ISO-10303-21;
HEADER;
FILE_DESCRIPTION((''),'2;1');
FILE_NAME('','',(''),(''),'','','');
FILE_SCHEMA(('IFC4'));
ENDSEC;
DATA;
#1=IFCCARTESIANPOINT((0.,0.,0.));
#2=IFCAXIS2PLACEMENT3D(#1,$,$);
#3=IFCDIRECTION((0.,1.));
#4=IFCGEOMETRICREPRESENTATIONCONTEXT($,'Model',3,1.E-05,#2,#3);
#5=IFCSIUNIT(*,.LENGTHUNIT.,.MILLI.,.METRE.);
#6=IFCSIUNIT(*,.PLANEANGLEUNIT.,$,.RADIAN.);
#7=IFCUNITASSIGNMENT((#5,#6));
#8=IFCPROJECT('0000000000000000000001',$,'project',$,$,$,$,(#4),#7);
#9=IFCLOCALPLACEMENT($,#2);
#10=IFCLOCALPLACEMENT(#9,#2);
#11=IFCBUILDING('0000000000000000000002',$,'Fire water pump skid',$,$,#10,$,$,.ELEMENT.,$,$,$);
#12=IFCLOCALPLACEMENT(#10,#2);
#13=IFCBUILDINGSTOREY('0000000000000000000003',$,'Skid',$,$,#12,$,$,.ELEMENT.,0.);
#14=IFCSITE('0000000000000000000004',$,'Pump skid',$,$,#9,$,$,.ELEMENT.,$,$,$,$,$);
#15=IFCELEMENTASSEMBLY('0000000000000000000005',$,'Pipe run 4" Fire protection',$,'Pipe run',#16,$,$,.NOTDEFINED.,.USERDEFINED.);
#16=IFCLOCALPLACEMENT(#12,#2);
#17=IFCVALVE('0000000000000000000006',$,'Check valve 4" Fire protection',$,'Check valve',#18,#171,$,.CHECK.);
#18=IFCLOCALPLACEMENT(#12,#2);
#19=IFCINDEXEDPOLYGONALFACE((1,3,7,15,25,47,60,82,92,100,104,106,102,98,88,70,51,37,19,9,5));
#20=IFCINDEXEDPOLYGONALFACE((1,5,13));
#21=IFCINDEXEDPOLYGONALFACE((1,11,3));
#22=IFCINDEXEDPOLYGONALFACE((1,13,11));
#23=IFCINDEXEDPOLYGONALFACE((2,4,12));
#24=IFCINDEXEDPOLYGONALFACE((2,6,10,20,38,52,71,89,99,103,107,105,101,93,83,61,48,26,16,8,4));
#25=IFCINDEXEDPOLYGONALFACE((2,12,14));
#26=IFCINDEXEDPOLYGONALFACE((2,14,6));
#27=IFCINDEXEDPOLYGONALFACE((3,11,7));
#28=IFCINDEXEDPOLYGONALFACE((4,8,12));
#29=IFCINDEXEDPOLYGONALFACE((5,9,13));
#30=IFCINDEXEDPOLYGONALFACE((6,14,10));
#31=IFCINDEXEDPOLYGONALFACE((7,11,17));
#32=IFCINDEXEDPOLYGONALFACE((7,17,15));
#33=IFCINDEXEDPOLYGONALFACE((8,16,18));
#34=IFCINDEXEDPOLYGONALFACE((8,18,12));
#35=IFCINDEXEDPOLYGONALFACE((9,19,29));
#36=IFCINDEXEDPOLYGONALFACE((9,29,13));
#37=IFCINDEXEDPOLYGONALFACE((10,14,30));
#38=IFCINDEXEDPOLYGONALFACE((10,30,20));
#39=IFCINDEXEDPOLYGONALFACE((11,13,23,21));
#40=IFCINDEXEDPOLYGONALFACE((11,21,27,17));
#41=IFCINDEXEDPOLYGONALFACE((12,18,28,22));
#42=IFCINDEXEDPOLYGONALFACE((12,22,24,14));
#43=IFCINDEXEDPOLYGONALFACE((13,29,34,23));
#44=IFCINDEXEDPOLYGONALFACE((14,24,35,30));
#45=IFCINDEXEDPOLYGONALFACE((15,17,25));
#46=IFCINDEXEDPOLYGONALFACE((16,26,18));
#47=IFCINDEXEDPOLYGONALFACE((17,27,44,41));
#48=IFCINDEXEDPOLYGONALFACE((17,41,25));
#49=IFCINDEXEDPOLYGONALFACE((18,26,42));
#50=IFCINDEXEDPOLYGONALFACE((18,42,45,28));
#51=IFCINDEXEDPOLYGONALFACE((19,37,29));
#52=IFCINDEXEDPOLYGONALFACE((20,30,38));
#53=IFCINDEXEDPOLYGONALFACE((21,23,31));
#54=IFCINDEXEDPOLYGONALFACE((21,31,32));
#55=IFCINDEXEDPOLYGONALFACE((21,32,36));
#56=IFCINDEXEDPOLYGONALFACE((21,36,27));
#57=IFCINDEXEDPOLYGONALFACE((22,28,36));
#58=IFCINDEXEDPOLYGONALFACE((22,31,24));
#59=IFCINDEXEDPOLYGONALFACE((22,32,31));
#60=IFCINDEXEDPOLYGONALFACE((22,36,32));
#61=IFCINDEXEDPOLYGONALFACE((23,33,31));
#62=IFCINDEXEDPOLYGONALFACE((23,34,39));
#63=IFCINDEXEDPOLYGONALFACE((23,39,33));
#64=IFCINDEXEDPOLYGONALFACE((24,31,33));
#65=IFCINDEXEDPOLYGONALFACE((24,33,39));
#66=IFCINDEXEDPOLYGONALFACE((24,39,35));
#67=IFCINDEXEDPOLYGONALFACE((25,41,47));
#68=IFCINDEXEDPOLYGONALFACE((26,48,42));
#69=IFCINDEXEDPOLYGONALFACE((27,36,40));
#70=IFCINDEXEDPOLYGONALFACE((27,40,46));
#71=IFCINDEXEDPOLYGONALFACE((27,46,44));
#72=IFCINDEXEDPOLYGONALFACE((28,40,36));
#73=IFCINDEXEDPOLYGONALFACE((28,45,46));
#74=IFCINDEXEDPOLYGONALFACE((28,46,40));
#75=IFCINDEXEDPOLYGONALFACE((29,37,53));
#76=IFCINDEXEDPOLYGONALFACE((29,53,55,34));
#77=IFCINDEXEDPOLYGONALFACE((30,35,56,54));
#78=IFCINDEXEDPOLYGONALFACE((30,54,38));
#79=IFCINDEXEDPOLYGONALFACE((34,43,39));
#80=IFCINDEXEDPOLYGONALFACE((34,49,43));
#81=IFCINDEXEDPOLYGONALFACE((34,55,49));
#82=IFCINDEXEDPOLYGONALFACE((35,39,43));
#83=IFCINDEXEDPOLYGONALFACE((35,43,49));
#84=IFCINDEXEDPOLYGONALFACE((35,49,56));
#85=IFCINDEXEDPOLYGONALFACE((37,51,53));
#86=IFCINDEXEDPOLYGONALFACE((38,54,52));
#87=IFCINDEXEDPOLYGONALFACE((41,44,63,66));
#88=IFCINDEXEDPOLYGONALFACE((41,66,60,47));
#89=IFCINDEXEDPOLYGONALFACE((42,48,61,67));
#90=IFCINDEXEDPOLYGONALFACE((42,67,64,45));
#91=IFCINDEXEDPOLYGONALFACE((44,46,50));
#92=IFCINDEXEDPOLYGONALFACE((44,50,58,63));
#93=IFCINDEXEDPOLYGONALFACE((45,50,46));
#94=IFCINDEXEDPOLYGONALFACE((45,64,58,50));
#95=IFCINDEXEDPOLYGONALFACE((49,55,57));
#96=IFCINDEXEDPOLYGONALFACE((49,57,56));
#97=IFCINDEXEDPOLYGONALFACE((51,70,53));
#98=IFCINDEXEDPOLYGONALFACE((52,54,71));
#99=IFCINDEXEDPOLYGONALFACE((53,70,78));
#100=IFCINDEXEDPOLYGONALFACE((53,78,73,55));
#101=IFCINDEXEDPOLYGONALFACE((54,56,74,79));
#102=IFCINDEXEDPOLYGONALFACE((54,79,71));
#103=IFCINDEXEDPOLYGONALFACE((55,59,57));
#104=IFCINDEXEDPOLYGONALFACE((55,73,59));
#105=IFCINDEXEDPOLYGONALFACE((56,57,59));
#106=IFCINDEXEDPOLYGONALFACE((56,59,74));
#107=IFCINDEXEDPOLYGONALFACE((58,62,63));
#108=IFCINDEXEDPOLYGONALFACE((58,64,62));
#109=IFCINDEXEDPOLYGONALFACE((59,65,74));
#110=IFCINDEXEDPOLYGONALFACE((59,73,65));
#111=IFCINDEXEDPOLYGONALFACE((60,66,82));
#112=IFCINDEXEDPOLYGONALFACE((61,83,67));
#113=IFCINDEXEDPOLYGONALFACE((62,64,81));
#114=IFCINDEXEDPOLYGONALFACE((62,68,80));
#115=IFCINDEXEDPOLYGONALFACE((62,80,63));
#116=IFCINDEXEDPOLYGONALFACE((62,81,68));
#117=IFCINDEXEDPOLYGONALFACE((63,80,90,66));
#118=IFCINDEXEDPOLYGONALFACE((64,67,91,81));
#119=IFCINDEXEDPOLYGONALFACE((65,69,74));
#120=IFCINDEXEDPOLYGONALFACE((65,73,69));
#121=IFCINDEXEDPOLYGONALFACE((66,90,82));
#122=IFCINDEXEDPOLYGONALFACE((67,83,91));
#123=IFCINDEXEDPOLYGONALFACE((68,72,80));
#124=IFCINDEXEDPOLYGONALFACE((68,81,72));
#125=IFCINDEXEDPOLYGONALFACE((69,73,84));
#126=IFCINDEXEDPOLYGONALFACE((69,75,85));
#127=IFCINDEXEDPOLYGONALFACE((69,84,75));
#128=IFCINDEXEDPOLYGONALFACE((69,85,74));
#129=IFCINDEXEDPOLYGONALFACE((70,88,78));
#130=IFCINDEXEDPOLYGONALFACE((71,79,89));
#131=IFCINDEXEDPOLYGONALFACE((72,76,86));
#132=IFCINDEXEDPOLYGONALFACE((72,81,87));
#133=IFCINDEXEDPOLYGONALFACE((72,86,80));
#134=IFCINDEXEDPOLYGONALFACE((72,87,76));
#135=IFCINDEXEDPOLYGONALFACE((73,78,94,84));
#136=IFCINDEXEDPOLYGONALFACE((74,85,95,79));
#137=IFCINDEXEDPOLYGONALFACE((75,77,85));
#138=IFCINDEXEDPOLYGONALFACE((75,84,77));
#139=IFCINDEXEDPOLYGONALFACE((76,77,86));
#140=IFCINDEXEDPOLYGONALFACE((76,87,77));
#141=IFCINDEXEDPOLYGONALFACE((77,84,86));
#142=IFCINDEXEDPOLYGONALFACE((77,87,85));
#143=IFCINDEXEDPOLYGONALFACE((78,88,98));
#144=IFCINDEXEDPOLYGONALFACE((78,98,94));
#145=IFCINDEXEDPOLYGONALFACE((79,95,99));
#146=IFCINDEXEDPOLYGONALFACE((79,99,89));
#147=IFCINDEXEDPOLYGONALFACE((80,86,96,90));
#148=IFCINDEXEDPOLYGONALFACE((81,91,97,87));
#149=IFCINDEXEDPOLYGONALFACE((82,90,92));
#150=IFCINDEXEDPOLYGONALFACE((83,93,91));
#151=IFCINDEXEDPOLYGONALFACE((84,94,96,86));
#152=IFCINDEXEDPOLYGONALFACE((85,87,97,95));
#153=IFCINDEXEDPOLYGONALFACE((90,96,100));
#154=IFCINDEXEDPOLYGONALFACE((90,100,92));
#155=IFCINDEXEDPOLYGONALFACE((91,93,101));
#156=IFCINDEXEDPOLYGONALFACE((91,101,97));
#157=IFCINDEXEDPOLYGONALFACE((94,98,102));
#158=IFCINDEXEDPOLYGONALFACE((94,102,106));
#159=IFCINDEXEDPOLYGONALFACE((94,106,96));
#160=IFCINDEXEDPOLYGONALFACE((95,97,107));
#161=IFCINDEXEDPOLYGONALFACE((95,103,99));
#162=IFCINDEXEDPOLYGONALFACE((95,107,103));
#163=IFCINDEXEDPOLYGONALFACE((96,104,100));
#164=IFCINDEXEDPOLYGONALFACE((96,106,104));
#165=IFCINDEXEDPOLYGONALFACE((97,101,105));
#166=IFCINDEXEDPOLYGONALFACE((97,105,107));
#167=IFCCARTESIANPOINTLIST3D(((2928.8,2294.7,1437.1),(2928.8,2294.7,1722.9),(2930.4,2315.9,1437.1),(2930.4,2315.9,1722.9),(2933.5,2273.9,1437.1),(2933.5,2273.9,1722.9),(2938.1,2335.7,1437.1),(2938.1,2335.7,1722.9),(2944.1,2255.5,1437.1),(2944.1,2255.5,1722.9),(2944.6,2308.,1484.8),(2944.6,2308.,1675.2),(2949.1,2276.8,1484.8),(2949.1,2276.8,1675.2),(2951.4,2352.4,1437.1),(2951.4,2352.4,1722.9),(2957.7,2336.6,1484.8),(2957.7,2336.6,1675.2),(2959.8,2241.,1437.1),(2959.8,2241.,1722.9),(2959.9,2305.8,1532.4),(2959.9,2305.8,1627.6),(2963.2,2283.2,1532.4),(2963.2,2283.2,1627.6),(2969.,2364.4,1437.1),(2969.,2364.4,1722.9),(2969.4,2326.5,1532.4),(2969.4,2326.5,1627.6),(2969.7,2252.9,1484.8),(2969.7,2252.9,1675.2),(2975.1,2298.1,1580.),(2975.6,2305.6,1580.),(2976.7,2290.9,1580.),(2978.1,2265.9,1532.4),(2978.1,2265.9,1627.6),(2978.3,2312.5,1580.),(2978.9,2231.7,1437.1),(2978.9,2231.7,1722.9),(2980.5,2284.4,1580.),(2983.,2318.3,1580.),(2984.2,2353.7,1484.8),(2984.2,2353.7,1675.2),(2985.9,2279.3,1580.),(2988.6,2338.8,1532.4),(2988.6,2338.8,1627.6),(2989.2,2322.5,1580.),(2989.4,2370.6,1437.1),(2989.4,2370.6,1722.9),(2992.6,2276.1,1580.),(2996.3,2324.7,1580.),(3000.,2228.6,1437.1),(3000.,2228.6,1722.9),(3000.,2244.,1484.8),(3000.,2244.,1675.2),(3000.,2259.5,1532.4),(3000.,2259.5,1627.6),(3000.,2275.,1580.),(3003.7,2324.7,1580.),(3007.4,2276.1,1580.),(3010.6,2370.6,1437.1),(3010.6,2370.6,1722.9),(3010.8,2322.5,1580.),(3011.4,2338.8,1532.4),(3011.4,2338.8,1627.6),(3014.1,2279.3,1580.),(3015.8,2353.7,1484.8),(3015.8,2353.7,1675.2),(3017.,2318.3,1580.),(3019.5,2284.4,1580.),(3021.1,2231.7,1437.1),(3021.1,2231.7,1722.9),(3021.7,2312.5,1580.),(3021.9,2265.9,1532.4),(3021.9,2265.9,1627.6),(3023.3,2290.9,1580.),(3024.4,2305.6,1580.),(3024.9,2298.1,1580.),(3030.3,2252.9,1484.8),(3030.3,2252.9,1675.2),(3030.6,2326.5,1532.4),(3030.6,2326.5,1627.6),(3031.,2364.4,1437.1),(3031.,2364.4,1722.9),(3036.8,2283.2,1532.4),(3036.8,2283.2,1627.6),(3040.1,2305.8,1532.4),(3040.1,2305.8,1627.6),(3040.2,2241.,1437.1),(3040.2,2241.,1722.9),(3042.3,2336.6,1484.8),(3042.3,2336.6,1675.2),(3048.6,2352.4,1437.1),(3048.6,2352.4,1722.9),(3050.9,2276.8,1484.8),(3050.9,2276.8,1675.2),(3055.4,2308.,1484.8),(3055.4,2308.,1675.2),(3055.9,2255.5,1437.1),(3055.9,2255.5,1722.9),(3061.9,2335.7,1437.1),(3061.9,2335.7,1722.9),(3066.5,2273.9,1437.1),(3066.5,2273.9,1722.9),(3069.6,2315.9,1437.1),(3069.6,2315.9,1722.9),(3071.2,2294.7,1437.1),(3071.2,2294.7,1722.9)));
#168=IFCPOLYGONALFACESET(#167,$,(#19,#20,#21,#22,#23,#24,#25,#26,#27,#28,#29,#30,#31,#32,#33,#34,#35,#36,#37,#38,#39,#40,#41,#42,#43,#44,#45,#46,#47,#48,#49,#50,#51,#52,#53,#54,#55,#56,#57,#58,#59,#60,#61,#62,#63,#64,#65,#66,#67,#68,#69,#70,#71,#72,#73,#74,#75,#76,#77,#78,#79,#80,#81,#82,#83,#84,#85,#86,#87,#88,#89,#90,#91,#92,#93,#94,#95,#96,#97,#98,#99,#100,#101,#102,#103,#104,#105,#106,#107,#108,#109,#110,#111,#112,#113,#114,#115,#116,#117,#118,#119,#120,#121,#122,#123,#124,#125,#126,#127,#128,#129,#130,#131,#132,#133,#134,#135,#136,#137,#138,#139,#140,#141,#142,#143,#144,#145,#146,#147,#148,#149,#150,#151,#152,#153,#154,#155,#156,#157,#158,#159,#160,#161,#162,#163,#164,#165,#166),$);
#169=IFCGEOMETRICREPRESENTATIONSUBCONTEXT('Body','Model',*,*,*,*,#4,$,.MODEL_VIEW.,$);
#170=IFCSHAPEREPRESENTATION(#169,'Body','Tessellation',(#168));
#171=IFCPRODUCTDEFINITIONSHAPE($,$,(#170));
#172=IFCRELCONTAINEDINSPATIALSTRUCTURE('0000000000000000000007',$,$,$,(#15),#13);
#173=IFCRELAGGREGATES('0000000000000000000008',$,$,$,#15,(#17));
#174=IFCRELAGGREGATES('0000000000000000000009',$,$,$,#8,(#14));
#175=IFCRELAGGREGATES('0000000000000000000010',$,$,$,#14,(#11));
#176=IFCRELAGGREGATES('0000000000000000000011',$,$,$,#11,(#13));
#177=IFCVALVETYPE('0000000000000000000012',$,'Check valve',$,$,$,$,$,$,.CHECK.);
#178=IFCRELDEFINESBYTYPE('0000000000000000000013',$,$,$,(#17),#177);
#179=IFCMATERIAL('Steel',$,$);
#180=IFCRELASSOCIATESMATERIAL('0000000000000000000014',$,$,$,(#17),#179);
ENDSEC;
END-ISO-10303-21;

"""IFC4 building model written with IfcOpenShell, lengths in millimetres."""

from ifc_helpers import new_model, entity, si_unit, direction, origin, origin_with_axes, place, context, subcontext, project, spatial, material, type_object, element, aggregate, save


model = new_model("IFC4")

# Units and contexts
model_context = context("Model", 3, precision=1e-05, world=origin(), true_north=direction((0.0, 1.0)))
body_context = subcontext(model_context, "Body", "Model", "MODEL_VIEW")
ifc_project = project(units=[si_unit("LENGTHUNIT", "METRE", prefix="MILLI"), si_unit("PLANEANGLEUNIT", "RADIAN")], contexts=[model_context])

# Site, building, storey
site_placement = place(None, origin())
site = spatial("IfcSite", under=ifc_project, at=site_placement, Name="Pump skid", CompositionType="ELEMENT")
building_placement = place(site_placement, origin())
building = spatial("IfcBuilding", under=site, at=building_placement, Name="Fire water pump skid", CompositionType="ELEMENT")
storey_placement = place(building_placement, origin())
storey = spatial("IfcBuildingStorey", under=building, at=storey_placement, Name="Skid", CompositionType="ELEMENT", Elevation=0.0)

# Element assembly
ifc_material = material(Name="Steel")
assembly_1_placement = place(storey_placement, origin_with_axes())
assembly_1 = element("IfcElementAssembly", 1, at=assembly_1_placement, inside=storey, Name="Pipe run 4\" Fire protection", ObjectType="Pipe run", AssemblyPlace="NOTDEFINED", PredefinedType="USERDEFINED")

# Valve
valve_type_1 = type_object("IfcValveType", Name="Check valve", PredefinedType="CHECK")
valve_1_placement = place(storey_placement, origin_with_axes())
cartesian_point_1 = entity("IfcCartesianPoint", [0.0, 0.0])
valve_1 = element("IfcValve", 2, at=valve_1_placement, type_object=valve_type_1, material=ifc_material, Name="Check valve 4\" Fire protection", ObjectType="Check valve", PredefinedType="CHECK", context=body_context, shape_type="SweptSolid", body=[
    entity("IfcRevolvedAreaSolid", entity("IfcArbitraryClosedProfileDef", "AREA", None, entity("IfcPolyline", [cartesian_point_1, entity("IfcCartesianPoint", [0.0, 71.4]), entity("IfcCartesianPoint", [142.9, 25.0]), entity("IfcCartesianPoint", [285.8, 71.4]), entity("IfcCartesianPoint", [285.8, 0.0]), cartesian_point_1])), entity("IfcAxis2Placement3D", entity("IfcCartesianPoint", [3000.0, 2300.0, 1437.1]), entity("IfcDirection", [1.0, 0.0, 0.0]), entity("IfcDirection", [0.0, 0.0, 1.0])), entity("IfcAxis1Placement", entity("IfcCartesianPoint", [0.0, 0.0, 0.0]), entity("IfcDirection", [1.0, 0.0, 0.0])), 6.283185),
])
aggregate(assembly_1, [valve_1])

save(model, "model.ifc")
